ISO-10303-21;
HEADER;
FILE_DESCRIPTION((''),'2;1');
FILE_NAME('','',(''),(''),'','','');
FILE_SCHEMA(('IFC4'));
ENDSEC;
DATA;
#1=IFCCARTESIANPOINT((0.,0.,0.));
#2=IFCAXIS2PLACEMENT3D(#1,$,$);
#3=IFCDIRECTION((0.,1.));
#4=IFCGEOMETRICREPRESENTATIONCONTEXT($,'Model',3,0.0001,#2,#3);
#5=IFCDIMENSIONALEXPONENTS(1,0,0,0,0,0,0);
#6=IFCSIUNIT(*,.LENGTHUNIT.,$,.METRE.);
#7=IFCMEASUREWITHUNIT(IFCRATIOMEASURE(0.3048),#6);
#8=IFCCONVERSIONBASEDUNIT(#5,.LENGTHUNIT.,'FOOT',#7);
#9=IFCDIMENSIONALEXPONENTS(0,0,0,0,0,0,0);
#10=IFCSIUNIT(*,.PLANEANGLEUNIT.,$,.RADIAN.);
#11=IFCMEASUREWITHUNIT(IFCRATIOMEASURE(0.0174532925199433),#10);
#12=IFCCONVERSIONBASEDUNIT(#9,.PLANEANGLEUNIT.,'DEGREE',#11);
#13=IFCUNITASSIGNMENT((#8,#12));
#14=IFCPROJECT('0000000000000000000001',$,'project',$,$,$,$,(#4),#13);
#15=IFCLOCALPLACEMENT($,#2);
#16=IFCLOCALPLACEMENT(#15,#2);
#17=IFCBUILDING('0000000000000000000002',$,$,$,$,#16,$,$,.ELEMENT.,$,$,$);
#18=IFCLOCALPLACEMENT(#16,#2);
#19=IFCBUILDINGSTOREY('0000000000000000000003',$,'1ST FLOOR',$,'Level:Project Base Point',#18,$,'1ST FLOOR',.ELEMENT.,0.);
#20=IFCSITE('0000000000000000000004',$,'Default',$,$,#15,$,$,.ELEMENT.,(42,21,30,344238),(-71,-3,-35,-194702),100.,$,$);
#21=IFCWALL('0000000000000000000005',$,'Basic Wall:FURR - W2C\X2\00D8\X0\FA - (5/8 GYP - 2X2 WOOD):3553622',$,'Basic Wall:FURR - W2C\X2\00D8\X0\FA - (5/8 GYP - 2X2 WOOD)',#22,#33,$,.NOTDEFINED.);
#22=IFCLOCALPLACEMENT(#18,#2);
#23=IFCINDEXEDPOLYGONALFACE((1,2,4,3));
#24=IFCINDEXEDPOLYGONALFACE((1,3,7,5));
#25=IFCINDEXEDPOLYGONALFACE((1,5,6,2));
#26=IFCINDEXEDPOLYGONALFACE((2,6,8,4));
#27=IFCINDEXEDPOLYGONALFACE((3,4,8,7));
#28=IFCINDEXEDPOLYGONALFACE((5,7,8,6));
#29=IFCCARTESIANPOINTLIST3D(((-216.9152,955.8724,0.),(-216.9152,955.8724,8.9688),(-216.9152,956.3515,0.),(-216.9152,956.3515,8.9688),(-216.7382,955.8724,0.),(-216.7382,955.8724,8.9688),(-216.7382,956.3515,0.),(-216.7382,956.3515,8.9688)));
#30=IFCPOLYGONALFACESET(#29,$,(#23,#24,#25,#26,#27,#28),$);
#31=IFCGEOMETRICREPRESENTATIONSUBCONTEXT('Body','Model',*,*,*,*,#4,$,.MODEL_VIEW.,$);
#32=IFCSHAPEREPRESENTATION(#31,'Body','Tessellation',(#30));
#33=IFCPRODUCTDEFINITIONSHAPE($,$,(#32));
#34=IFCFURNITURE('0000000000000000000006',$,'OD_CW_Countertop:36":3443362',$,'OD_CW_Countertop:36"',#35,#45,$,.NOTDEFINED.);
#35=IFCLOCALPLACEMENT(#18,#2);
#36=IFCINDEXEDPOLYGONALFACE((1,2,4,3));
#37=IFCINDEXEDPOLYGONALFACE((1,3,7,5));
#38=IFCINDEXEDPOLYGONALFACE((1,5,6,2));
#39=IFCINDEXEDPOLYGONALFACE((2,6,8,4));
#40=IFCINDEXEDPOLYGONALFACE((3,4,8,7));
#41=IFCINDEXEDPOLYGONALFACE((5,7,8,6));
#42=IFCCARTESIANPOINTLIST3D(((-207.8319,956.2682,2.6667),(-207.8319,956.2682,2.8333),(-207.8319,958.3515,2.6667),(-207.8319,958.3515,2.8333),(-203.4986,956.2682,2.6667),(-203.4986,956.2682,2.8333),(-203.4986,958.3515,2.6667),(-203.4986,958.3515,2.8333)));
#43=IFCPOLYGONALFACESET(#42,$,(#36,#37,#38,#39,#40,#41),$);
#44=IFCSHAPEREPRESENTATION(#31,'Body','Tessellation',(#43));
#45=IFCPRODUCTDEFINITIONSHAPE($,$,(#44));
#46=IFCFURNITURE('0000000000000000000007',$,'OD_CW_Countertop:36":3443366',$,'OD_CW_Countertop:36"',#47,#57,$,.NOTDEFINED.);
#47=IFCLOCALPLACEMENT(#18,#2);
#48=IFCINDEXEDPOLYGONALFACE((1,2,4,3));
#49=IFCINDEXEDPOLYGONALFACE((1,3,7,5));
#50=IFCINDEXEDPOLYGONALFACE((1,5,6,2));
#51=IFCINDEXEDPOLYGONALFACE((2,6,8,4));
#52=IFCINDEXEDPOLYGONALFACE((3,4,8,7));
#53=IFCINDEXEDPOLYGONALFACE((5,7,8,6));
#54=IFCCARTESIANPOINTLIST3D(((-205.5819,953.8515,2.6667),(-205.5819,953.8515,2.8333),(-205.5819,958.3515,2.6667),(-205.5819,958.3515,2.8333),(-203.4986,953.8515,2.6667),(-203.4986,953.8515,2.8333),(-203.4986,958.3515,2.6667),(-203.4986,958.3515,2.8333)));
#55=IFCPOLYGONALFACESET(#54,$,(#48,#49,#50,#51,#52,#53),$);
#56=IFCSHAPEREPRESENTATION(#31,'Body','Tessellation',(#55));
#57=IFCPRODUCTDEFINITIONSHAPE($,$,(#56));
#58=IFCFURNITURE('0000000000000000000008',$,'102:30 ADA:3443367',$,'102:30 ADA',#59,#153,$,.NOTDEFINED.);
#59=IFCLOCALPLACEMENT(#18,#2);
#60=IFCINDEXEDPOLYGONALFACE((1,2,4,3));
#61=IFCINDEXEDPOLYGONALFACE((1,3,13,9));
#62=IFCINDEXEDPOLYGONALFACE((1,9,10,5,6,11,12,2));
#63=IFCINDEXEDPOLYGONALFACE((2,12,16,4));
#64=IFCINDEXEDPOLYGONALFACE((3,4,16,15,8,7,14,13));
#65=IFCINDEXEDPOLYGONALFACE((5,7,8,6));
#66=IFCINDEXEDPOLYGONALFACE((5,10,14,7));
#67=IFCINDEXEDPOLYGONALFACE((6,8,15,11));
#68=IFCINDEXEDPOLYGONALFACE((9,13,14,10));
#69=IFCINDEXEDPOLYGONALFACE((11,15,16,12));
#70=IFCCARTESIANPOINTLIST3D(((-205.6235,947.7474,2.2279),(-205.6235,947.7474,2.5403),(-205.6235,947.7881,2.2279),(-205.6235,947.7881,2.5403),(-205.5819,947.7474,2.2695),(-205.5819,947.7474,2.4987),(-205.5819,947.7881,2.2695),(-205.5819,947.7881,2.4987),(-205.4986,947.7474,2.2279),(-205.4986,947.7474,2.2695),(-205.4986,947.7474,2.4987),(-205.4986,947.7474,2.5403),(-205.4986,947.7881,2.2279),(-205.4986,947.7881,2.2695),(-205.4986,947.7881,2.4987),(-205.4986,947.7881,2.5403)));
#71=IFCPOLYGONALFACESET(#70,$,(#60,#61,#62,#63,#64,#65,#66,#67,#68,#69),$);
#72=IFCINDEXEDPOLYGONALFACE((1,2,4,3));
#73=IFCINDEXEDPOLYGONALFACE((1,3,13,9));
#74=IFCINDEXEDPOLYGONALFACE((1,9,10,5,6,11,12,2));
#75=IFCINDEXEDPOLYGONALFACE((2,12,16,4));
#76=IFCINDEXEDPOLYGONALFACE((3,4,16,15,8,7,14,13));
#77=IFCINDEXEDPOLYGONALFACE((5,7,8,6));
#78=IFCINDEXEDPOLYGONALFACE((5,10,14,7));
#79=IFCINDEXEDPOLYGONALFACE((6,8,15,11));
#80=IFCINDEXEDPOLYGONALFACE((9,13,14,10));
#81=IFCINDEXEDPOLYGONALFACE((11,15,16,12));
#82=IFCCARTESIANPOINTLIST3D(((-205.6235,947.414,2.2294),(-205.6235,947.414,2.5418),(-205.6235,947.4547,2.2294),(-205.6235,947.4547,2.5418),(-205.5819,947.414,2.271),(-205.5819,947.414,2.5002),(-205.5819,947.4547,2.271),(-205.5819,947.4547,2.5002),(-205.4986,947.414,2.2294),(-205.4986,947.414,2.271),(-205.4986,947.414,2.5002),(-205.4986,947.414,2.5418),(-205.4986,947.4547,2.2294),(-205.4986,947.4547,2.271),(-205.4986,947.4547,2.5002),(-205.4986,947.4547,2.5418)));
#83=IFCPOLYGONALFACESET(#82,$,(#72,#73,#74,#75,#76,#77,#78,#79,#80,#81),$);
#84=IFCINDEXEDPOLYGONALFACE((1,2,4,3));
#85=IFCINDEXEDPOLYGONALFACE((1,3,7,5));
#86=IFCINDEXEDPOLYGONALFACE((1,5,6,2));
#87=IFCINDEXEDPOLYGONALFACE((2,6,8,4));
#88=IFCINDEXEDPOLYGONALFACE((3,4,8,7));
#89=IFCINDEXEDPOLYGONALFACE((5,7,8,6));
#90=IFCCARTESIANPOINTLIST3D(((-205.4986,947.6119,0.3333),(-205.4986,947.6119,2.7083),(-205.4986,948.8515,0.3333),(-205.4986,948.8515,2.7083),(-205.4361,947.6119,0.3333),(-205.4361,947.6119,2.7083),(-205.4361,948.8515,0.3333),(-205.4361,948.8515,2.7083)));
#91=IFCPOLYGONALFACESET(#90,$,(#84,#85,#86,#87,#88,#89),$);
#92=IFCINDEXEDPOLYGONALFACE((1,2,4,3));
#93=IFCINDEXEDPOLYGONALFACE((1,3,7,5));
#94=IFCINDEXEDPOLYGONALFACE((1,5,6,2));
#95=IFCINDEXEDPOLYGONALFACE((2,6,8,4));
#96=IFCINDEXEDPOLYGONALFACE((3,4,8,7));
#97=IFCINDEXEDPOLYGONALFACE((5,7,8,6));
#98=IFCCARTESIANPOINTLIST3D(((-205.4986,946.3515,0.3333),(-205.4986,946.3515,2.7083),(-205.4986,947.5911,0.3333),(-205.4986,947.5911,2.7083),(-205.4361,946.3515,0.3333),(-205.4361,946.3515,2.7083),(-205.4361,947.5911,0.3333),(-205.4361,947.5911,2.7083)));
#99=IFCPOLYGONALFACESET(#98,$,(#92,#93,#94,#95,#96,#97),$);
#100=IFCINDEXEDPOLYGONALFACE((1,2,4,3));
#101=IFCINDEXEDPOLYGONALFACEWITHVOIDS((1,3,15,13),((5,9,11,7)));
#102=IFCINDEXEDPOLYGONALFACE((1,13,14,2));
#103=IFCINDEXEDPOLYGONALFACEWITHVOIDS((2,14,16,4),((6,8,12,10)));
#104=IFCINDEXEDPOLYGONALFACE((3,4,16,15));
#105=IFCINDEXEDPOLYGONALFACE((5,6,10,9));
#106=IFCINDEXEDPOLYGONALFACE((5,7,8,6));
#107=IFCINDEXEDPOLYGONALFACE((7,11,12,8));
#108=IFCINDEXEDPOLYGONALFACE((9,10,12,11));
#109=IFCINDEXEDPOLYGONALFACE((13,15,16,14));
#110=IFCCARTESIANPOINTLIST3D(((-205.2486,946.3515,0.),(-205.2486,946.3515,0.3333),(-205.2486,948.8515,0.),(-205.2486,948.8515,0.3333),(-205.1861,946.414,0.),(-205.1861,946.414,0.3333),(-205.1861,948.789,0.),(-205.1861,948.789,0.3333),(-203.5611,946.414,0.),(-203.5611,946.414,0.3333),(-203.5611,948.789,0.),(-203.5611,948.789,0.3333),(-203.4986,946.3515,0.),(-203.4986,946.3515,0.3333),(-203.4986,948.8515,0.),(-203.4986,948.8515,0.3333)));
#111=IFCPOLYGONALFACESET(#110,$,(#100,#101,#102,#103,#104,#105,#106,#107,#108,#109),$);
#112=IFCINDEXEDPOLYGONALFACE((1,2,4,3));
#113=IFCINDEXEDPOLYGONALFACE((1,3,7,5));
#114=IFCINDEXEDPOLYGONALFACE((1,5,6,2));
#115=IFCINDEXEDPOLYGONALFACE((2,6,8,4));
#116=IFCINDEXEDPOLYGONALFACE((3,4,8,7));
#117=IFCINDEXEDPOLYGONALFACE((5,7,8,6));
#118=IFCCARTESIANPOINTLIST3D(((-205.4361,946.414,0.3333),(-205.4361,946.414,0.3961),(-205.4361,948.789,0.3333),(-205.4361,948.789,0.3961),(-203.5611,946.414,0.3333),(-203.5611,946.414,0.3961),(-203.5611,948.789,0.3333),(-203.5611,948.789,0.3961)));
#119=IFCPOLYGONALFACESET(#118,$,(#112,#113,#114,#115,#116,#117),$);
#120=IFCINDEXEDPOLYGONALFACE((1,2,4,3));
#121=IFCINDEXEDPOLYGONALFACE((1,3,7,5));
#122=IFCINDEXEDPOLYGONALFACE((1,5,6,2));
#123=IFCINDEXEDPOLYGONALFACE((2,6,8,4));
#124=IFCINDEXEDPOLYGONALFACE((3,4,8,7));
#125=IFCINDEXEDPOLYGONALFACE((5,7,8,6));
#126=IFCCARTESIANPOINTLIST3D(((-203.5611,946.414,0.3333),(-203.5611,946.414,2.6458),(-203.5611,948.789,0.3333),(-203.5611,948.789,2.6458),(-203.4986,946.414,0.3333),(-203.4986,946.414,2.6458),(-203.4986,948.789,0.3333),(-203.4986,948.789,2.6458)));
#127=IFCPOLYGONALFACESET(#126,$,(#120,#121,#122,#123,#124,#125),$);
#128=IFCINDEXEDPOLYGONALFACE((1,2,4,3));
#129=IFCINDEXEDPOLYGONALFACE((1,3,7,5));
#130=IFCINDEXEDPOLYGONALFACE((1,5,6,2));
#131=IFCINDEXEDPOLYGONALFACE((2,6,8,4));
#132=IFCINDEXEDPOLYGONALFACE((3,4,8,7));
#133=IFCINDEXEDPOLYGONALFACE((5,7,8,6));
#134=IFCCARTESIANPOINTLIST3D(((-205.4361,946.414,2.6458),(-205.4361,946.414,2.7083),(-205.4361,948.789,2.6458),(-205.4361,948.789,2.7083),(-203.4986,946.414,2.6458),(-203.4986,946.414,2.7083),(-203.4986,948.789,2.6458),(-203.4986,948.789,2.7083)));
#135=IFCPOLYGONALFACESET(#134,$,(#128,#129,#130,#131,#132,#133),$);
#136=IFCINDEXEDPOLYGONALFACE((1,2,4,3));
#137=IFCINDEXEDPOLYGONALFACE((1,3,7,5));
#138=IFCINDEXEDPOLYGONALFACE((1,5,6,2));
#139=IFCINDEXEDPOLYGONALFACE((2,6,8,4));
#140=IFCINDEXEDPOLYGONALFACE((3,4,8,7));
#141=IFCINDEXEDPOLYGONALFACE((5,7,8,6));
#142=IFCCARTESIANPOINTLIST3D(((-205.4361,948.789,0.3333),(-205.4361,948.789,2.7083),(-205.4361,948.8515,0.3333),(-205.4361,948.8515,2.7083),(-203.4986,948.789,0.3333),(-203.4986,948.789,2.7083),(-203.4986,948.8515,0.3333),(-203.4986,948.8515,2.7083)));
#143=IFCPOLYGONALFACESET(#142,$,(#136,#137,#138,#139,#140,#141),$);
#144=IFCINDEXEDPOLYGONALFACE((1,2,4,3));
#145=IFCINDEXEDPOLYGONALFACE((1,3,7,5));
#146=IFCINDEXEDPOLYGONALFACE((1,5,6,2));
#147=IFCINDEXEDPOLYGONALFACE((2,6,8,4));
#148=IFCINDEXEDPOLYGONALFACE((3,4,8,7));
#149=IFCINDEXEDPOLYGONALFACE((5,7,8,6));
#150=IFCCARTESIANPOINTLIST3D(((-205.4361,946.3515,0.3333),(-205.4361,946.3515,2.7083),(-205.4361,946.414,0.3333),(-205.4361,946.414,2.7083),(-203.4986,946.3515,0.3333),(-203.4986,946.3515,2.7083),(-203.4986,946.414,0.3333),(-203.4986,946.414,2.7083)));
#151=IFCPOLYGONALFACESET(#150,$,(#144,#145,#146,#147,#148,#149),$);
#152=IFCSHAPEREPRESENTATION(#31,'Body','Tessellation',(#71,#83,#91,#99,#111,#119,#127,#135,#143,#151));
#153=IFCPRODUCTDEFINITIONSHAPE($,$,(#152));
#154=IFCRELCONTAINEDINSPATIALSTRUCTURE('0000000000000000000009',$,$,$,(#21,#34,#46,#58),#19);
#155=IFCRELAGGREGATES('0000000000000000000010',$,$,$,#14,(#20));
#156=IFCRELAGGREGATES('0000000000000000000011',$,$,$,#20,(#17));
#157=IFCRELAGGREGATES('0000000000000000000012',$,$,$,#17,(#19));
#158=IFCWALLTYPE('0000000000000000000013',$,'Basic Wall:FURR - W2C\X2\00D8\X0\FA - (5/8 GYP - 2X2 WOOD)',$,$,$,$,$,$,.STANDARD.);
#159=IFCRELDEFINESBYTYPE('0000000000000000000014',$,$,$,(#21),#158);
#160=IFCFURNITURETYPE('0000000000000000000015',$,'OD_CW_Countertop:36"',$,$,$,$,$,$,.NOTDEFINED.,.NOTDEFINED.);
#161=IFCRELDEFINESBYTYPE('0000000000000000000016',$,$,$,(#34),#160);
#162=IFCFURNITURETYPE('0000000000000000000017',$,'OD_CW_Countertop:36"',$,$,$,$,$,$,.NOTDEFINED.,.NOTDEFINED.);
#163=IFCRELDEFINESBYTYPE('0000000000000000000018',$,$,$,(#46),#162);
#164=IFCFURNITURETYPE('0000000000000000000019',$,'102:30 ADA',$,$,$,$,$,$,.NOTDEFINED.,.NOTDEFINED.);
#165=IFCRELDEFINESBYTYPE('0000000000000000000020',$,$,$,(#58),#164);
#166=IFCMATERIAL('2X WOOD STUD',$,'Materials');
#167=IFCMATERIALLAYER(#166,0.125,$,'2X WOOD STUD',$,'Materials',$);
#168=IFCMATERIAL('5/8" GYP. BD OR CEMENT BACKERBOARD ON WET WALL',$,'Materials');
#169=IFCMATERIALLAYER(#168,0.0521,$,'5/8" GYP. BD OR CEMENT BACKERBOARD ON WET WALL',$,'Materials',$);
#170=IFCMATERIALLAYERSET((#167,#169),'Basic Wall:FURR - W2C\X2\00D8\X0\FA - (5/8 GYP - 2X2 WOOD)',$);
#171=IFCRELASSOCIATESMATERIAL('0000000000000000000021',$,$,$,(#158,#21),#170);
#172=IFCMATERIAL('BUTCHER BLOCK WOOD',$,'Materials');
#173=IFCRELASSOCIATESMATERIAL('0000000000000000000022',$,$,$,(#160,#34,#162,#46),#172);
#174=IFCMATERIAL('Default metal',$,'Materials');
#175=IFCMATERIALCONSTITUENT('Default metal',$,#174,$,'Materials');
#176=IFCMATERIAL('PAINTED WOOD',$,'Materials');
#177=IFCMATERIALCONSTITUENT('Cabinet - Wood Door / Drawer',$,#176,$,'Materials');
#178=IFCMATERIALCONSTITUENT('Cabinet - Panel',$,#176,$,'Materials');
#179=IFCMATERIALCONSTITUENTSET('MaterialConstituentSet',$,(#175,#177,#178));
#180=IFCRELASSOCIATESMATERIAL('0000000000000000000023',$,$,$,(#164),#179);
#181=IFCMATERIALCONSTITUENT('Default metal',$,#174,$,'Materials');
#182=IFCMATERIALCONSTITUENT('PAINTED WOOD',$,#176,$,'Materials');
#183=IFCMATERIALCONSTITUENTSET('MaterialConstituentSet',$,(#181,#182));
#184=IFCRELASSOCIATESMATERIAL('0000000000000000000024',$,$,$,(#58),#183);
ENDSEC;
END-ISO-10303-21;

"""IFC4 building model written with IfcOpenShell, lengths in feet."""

from ifc_helpers import new_model, entity, si_unit, converted_unit, direction, frame, frame_2d, origin, origin_2d_with_axis, place, context, subcontext, project, spatial, polyline, rectangle, outline, extrude, source, transform, mapped, material, layer, layer_set, layer_usage, constituent, constituent_set, type_object, type_shapes, element, save


model = new_model("IFC4")

# Units and contexts
model_context = context("Model", 3, precision=0.0001, world=origin(), true_north=direction((0.0, 1.0)))
body_context = subcontext(model_context, "Body", "Model", "MODEL_VIEW")
ifc_project = project(units=[converted_unit("LENGTHUNIT", "FOOT", entity("IfcRatioMeasure", 0.3048), si_unit("LENGTHUNIT", "METRE"), dimensions=[1, 0, 0, 0, 0, 0, 0]), converted_unit("PLANEANGLEUNIT", "DEGREE", entity("IfcRatioMeasure", 0.0174532925199433), si_unit("PLANEANGLEUNIT", "RADIAN"), dimensions=[0, 0, 0, 0, 0, 0, 0])], contexts=[model_context])

# Site, building, storey
site_placement = place(None, origin())
site = spatial("IfcSite", under=ifc_project, at=site_placement, Name="Default", CompositionType="ELEMENT", RefLatitude=(42, 21, 30, 344238), RefLongitude=(-71, -3, -35, -194702), RefElevation=100.0)
building_placement = place(site_placement, origin())
building = spatial("IfcBuilding", under=site, at=building_placement, CompositionType="ELEMENT")
storey_placement = place(building_placement, origin())
storey = spatial("IfcBuildingStorey", under=building, at=storey_placement, Name="1ST FLOOR", ObjectType="Level:Project Base Point", LongName="1ST FLOOR", CompositionType="ELEMENT", Elevation=0.0)

# Shared definitions
ifc_material_1 = material(Name="5/8\" GYP. BD OR CEMENT BACKERBOARD ON WET WALL", Category="Materials")

# Wall
ifc_material_2 = material(Name="2X WOOD STUD", Category="Materials")
ifc_layer_1 = layer(ifc_material_2, 0.125, Name="2X WOOD STUD", Category="Materials")
ifc_layer_2 = layer(ifc_material_1, 0.0521, Name="5/8\" GYP. BD OR CEMENT BACKERBOARD ON WET WALL", Category="Materials")
ifc_layer_set_1 = layer_set([ifc_layer_1, ifc_layer_2], Name="Basic Wall:FURR - W2CØFA - (5/8 GYP - 2X2 WOOD)")
ifc_layer_usage_1 = layer_usage(ifc_layer_set_1, "AXIS2", "NEGATIVE", 0.0885)
wall_type_1 = type_object("IfcWallType", Name="Basic Wall:FURR - W2CØFA - (5/8 GYP - 2X2 WOOD)", PredefinedType="STANDARD", material=ifc_layer_set_1)
wall_1_placement = place(storey_placement, frame((-216.8267, 956.3515, 0.0), z_axis=(0.0, 0.0, 1.0), x_axis=(0.0, -1.0, 0.0)))
element("IfcWall", 1, at=wall_1_placement, inside=storey, type_object=wall_type_1, material=ifc_layer_usage_1, Name="Basic Wall:FURR - W2CØFA - (5/8 GYP - 2X2 WOOD):3553622", ObjectType="Basic Wall:FURR - W2CØFA - (5/8 GYP - 2X2 WOOD)", PredefinedType="NOTDEFINED", context=body_context, shape_type="SweptSolid", body=[
    extrude(rectangle(XDim=0.4792, YDim=0.1771, at=frame_2d((0.2396, 0.0), x_axis=(-1.0, 0.0))), origin(), (0.0, 0.0, 1.0), 8.9688),
])

# Furniture
ifc_material_3 = material(Name="Default metal", Category="Materials")
ifc_material_4 = material(Name="PAINTED WOOD", Category="Materials")
ifc_material_5 = material(Name="BUTCHER BLOCK WOOD", Category="Materials")
furniture_type_1 = type_object("IfcFurnitureType", Name="OD_CW_Countertop:36\"", AssemblyPlace="NOTDEFINED", PredefinedType="NOTDEFINED", material=ifc_material_5)
shared_shape_1 = source(origin(), body_context, "Body", "SweptSolid", [
    extrude(rectangle(XDim=2.0833, YDim=4.3333, at=frame_2d((0.0, 0.0), x_axis=(1.0, 0.0))), frame((2.1667, 1.0417, 0.0), z_axis=(0.0, 0.0, 1.0), x_axis=(0.0, -1.0, 0.0)), (0.0, 0.0, 1.0), 0.1667),
])
type_shapes(furniture_type_1, [shared_shape_1])
furniture_1_placement = place(storey_placement, frame((-207.8319, 956.2682, 2.6667)))
element("IfcFurniture", 2, at=furniture_1_placement, inside=storey, type_object=furniture_type_1, material=ifc_material_5, Name="OD_CW_Countertop:36\":3443362", ObjectType="OD_CW_Countertop:36\"", PredefinedType="NOTDEFINED", context=body_context, shape_type="MappedRepresentation", body=[
    mapped(shared_shape_1, transform((0.0, 0.0, 0.0), scale=1.0)),
])
furniture_type_2 = type_object("IfcFurnitureType", Name="OD_CW_Countertop:36\"", AssemblyPlace="NOTDEFINED", PredefinedType="NOTDEFINED", material=ifc_material_5)
shared_shape_2 = source(origin(), body_context, "Body", "SweptSolid", [
    extrude(rectangle(XDim=2.0833, YDim=4.5, at=origin_2d_with_axis()), frame((2.25, 1.0417, 0.0), z_axis=(0.0, 0.0, 1.0), x_axis=(0.0, -1.0, 0.0)), (0.0, 0.0, 1.0), 0.1667),
])
type_shapes(furniture_type_2, [shared_shape_2])
furniture_2_placement = place(storey_placement, frame((-205.5819, 958.3515, 2.6667), z_axis=(0.0, 0.0, 1.0), x_axis=(0.0, -1.0, 0.0)))
element("IfcFurniture", 3, at=furniture_2_placement, inside=storey, type_object=furniture_type_2, material=ifc_material_5, Name="OD_CW_Countertop:36\":3443366", ObjectType="OD_CW_Countertop:36\"", PredefinedType="NOTDEFINED", context=body_context, shape_type="MappedRepresentation", body=[
    mapped(shared_shape_2, transform((0.0, 0.0, 0.0), scale=1.0)),
])
ifc_constituent_1 = constituent(ifc_material_3, Name="Default metal", Category="Materials")
ifc_constituent_2 = constituent(ifc_material_4, Name="PAINTED WOOD", Category="Materials")
ifc_constituent_set_1 = constituent_set(constituents=[ifc_constituent_1, ifc_constituent_2], Name="MaterialConstituentSet")
ifc_constituent_3 = constituent(ifc_material_3, Name="Default metal", Category="Materials")
ifc_constituent_4 = constituent(ifc_material_4, Name="Cabinet - Wood Door / Drawer", Category="Materials")
ifc_constituent_5 = constituent(ifc_material_4, Name="Cabinet - Panel", Category="Materials")
ifc_constituent_set_2 = constituent_set(constituents=[ifc_constituent_3, ifc_constituent_4, ifc_constituent_5], Name="MaterialConstituentSet")
furniture_type_3 = type_object("IfcFurnitureType", Name="102:30 ADA", AssemblyPlace="NOTDEFINED", PredefinedType="NOTDEFINED", material=ifc_constituent_set_2)
shared_shape_3 = source(origin(), body_context, "Body", "SweptSolid", [
    extrude(outline(polyline([(-0.0521, -0.1146), (-0.0521, -0.1562), (0.0729, -0.1562), (0.0729, 0.1562), (-0.0521, 0.1562), (-0.0521, 0.1146), (0.0313, 0.1146), (0.0313, -0.1146), (-0.0521, -0.1146)])), frame((0.2073, 2.0521, 2.3841), z_axis=(-1.0, 0.0, 0.0), x_axis=(0.0, 1.0, 0.0)), (0.0, 0.0, -1.0), 0.0407),
    extrude(outline(polyline([(-0.0521, -0.1146), (-0.0521, -0.1562), (0.0729, -0.1562), (0.0729, 0.1562), (-0.0521, 0.1562), (-0.0521, 0.1146), (0.0313, 0.1146), (0.0313, -0.1146), (-0.0521, -0.1146)])), frame((-0.126, 2.0521, 2.3856), z_axis=(-1.0, 0.0, 0.0), x_axis=(0.0, 1.0, 0.0)), (0.0, 0.0, -1.0), 0.0407),
    extrude(rectangle(XDim=1.2396, YDim=0.0625, at=frame_2d((0.0, 0.0), x_axis=(1.0, 0.0))), frame((0.6917, 1.9688, 0.3333), z_axis=(0.0, 0.0, 1.0), x_axis=(-1.0, 0.0, 0.0)), (0.0, 0.0, 1.0), 2.375),
    extrude(rectangle(XDim=1.2396, YDim=0.0625, at=frame_2d((0.0, 0.0), x_axis=(1.0, 0.0))), frame((-0.5687, 1.9688, 0.3333), z_axis=(0.0, 0.0, 1.0), x_axis=(-1.0, 0.0, 0.0)), (0.0, 0.0, 1.0), 2.375),
    extrude(outline(polyline([(-0.875, -1.25), (0.875, -1.25), (0.875, 1.25), (-0.875, 1.25), (-0.875, -1.25)]), holes=[polyline([(-0.8125, -1.1875), (-0.8125, 1.1875), (0.8125, 1.1875), (0.8125, -1.1875), (-0.8125, -1.1875)])]), frame((0.0615, 0.875, 0.0), z_axis=(0.0, 0.0, 1.0), x_axis=(0.0, -1.0, 0.0)), (0.0, 0.0, 1.0), 0.3333),
    extrude(rectangle(XDim=1.875, YDim=2.375, at=origin_2d_with_axis()), frame((0.0615, 1.0, 0.3333), z_axis=(0.0, 0.0, 1.0), x_axis=(0.0, 1.0, 0.0)), (0.0, 0.0, 1.0), 0.0627),
    extrude(rectangle(XDim=2.375, YDim=0.0625, at=origin_2d_with_axis()), frame((0.0615, 0.0312, 0.3333), z_axis=(0.0, 0.0, 1.0), x_axis=(-1.0, 0.0, 0.0)), (0.0, 0.0, 1.0), 2.3125),
    extrude(rectangle(XDim=1.9375, YDim=2.375, at=frame_2d((0.0, 0.0), x_axis=(1.0, 0.0))), frame((0.0615, 0.9688, 2.6458), z_axis=(0.0, 0.0, 1.0), x_axis=(0.0, 1.0, 0.0)), (0.0, 0.0, 1.0), 0.0625),
    extrude(rectangle(XDim=1.9375, YDim=0.0625, at=frame_2d((0.0, 0.0), x_axis=(1.0, 0.0))), frame((1.2802, 0.9687, 0.3333), z_axis=(0.0, 0.0, 1.0), x_axis=(0.0, -1.0, 0.0)), (0.0, 0.0, 1.0), 2.375),
    extrude(rectangle(XDim=1.9375, YDim=0.0625, at=frame_2d((0.0, 0.0), x_axis=(1.0, 0.0))), frame((-1.1573, 0.9687, 0.3333), z_axis=(0.0, 0.0, 1.0), x_axis=(0.0, -1.0, 0.0)), (0.0, 0.0, 1.0), 2.375),
])
type_shapes(furniture_type_3, [shared_shape_3])
furniture_3_placement = place(storey_placement, frame((-203.4986, 947.54, 0.0), z_axis=(0.0, 0.0, 1.0), x_axis=(0.0, 1.0, 0.0)))
element("IfcFurniture", 4, at=furniture_3_placement, inside=storey, type_object=furniture_type_3, material=ifc_constituent_set_1, Name="102:30 ADA:3443367", ObjectType="102:30 ADA", PredefinedType="NOTDEFINED", context=body_context, shape_type="MappedRepresentation", body=[
    mapped(shared_shape_3, transform((0.0, 0.0, 0.0), scale=1.0)),
])

save(model, "model.ifc")
